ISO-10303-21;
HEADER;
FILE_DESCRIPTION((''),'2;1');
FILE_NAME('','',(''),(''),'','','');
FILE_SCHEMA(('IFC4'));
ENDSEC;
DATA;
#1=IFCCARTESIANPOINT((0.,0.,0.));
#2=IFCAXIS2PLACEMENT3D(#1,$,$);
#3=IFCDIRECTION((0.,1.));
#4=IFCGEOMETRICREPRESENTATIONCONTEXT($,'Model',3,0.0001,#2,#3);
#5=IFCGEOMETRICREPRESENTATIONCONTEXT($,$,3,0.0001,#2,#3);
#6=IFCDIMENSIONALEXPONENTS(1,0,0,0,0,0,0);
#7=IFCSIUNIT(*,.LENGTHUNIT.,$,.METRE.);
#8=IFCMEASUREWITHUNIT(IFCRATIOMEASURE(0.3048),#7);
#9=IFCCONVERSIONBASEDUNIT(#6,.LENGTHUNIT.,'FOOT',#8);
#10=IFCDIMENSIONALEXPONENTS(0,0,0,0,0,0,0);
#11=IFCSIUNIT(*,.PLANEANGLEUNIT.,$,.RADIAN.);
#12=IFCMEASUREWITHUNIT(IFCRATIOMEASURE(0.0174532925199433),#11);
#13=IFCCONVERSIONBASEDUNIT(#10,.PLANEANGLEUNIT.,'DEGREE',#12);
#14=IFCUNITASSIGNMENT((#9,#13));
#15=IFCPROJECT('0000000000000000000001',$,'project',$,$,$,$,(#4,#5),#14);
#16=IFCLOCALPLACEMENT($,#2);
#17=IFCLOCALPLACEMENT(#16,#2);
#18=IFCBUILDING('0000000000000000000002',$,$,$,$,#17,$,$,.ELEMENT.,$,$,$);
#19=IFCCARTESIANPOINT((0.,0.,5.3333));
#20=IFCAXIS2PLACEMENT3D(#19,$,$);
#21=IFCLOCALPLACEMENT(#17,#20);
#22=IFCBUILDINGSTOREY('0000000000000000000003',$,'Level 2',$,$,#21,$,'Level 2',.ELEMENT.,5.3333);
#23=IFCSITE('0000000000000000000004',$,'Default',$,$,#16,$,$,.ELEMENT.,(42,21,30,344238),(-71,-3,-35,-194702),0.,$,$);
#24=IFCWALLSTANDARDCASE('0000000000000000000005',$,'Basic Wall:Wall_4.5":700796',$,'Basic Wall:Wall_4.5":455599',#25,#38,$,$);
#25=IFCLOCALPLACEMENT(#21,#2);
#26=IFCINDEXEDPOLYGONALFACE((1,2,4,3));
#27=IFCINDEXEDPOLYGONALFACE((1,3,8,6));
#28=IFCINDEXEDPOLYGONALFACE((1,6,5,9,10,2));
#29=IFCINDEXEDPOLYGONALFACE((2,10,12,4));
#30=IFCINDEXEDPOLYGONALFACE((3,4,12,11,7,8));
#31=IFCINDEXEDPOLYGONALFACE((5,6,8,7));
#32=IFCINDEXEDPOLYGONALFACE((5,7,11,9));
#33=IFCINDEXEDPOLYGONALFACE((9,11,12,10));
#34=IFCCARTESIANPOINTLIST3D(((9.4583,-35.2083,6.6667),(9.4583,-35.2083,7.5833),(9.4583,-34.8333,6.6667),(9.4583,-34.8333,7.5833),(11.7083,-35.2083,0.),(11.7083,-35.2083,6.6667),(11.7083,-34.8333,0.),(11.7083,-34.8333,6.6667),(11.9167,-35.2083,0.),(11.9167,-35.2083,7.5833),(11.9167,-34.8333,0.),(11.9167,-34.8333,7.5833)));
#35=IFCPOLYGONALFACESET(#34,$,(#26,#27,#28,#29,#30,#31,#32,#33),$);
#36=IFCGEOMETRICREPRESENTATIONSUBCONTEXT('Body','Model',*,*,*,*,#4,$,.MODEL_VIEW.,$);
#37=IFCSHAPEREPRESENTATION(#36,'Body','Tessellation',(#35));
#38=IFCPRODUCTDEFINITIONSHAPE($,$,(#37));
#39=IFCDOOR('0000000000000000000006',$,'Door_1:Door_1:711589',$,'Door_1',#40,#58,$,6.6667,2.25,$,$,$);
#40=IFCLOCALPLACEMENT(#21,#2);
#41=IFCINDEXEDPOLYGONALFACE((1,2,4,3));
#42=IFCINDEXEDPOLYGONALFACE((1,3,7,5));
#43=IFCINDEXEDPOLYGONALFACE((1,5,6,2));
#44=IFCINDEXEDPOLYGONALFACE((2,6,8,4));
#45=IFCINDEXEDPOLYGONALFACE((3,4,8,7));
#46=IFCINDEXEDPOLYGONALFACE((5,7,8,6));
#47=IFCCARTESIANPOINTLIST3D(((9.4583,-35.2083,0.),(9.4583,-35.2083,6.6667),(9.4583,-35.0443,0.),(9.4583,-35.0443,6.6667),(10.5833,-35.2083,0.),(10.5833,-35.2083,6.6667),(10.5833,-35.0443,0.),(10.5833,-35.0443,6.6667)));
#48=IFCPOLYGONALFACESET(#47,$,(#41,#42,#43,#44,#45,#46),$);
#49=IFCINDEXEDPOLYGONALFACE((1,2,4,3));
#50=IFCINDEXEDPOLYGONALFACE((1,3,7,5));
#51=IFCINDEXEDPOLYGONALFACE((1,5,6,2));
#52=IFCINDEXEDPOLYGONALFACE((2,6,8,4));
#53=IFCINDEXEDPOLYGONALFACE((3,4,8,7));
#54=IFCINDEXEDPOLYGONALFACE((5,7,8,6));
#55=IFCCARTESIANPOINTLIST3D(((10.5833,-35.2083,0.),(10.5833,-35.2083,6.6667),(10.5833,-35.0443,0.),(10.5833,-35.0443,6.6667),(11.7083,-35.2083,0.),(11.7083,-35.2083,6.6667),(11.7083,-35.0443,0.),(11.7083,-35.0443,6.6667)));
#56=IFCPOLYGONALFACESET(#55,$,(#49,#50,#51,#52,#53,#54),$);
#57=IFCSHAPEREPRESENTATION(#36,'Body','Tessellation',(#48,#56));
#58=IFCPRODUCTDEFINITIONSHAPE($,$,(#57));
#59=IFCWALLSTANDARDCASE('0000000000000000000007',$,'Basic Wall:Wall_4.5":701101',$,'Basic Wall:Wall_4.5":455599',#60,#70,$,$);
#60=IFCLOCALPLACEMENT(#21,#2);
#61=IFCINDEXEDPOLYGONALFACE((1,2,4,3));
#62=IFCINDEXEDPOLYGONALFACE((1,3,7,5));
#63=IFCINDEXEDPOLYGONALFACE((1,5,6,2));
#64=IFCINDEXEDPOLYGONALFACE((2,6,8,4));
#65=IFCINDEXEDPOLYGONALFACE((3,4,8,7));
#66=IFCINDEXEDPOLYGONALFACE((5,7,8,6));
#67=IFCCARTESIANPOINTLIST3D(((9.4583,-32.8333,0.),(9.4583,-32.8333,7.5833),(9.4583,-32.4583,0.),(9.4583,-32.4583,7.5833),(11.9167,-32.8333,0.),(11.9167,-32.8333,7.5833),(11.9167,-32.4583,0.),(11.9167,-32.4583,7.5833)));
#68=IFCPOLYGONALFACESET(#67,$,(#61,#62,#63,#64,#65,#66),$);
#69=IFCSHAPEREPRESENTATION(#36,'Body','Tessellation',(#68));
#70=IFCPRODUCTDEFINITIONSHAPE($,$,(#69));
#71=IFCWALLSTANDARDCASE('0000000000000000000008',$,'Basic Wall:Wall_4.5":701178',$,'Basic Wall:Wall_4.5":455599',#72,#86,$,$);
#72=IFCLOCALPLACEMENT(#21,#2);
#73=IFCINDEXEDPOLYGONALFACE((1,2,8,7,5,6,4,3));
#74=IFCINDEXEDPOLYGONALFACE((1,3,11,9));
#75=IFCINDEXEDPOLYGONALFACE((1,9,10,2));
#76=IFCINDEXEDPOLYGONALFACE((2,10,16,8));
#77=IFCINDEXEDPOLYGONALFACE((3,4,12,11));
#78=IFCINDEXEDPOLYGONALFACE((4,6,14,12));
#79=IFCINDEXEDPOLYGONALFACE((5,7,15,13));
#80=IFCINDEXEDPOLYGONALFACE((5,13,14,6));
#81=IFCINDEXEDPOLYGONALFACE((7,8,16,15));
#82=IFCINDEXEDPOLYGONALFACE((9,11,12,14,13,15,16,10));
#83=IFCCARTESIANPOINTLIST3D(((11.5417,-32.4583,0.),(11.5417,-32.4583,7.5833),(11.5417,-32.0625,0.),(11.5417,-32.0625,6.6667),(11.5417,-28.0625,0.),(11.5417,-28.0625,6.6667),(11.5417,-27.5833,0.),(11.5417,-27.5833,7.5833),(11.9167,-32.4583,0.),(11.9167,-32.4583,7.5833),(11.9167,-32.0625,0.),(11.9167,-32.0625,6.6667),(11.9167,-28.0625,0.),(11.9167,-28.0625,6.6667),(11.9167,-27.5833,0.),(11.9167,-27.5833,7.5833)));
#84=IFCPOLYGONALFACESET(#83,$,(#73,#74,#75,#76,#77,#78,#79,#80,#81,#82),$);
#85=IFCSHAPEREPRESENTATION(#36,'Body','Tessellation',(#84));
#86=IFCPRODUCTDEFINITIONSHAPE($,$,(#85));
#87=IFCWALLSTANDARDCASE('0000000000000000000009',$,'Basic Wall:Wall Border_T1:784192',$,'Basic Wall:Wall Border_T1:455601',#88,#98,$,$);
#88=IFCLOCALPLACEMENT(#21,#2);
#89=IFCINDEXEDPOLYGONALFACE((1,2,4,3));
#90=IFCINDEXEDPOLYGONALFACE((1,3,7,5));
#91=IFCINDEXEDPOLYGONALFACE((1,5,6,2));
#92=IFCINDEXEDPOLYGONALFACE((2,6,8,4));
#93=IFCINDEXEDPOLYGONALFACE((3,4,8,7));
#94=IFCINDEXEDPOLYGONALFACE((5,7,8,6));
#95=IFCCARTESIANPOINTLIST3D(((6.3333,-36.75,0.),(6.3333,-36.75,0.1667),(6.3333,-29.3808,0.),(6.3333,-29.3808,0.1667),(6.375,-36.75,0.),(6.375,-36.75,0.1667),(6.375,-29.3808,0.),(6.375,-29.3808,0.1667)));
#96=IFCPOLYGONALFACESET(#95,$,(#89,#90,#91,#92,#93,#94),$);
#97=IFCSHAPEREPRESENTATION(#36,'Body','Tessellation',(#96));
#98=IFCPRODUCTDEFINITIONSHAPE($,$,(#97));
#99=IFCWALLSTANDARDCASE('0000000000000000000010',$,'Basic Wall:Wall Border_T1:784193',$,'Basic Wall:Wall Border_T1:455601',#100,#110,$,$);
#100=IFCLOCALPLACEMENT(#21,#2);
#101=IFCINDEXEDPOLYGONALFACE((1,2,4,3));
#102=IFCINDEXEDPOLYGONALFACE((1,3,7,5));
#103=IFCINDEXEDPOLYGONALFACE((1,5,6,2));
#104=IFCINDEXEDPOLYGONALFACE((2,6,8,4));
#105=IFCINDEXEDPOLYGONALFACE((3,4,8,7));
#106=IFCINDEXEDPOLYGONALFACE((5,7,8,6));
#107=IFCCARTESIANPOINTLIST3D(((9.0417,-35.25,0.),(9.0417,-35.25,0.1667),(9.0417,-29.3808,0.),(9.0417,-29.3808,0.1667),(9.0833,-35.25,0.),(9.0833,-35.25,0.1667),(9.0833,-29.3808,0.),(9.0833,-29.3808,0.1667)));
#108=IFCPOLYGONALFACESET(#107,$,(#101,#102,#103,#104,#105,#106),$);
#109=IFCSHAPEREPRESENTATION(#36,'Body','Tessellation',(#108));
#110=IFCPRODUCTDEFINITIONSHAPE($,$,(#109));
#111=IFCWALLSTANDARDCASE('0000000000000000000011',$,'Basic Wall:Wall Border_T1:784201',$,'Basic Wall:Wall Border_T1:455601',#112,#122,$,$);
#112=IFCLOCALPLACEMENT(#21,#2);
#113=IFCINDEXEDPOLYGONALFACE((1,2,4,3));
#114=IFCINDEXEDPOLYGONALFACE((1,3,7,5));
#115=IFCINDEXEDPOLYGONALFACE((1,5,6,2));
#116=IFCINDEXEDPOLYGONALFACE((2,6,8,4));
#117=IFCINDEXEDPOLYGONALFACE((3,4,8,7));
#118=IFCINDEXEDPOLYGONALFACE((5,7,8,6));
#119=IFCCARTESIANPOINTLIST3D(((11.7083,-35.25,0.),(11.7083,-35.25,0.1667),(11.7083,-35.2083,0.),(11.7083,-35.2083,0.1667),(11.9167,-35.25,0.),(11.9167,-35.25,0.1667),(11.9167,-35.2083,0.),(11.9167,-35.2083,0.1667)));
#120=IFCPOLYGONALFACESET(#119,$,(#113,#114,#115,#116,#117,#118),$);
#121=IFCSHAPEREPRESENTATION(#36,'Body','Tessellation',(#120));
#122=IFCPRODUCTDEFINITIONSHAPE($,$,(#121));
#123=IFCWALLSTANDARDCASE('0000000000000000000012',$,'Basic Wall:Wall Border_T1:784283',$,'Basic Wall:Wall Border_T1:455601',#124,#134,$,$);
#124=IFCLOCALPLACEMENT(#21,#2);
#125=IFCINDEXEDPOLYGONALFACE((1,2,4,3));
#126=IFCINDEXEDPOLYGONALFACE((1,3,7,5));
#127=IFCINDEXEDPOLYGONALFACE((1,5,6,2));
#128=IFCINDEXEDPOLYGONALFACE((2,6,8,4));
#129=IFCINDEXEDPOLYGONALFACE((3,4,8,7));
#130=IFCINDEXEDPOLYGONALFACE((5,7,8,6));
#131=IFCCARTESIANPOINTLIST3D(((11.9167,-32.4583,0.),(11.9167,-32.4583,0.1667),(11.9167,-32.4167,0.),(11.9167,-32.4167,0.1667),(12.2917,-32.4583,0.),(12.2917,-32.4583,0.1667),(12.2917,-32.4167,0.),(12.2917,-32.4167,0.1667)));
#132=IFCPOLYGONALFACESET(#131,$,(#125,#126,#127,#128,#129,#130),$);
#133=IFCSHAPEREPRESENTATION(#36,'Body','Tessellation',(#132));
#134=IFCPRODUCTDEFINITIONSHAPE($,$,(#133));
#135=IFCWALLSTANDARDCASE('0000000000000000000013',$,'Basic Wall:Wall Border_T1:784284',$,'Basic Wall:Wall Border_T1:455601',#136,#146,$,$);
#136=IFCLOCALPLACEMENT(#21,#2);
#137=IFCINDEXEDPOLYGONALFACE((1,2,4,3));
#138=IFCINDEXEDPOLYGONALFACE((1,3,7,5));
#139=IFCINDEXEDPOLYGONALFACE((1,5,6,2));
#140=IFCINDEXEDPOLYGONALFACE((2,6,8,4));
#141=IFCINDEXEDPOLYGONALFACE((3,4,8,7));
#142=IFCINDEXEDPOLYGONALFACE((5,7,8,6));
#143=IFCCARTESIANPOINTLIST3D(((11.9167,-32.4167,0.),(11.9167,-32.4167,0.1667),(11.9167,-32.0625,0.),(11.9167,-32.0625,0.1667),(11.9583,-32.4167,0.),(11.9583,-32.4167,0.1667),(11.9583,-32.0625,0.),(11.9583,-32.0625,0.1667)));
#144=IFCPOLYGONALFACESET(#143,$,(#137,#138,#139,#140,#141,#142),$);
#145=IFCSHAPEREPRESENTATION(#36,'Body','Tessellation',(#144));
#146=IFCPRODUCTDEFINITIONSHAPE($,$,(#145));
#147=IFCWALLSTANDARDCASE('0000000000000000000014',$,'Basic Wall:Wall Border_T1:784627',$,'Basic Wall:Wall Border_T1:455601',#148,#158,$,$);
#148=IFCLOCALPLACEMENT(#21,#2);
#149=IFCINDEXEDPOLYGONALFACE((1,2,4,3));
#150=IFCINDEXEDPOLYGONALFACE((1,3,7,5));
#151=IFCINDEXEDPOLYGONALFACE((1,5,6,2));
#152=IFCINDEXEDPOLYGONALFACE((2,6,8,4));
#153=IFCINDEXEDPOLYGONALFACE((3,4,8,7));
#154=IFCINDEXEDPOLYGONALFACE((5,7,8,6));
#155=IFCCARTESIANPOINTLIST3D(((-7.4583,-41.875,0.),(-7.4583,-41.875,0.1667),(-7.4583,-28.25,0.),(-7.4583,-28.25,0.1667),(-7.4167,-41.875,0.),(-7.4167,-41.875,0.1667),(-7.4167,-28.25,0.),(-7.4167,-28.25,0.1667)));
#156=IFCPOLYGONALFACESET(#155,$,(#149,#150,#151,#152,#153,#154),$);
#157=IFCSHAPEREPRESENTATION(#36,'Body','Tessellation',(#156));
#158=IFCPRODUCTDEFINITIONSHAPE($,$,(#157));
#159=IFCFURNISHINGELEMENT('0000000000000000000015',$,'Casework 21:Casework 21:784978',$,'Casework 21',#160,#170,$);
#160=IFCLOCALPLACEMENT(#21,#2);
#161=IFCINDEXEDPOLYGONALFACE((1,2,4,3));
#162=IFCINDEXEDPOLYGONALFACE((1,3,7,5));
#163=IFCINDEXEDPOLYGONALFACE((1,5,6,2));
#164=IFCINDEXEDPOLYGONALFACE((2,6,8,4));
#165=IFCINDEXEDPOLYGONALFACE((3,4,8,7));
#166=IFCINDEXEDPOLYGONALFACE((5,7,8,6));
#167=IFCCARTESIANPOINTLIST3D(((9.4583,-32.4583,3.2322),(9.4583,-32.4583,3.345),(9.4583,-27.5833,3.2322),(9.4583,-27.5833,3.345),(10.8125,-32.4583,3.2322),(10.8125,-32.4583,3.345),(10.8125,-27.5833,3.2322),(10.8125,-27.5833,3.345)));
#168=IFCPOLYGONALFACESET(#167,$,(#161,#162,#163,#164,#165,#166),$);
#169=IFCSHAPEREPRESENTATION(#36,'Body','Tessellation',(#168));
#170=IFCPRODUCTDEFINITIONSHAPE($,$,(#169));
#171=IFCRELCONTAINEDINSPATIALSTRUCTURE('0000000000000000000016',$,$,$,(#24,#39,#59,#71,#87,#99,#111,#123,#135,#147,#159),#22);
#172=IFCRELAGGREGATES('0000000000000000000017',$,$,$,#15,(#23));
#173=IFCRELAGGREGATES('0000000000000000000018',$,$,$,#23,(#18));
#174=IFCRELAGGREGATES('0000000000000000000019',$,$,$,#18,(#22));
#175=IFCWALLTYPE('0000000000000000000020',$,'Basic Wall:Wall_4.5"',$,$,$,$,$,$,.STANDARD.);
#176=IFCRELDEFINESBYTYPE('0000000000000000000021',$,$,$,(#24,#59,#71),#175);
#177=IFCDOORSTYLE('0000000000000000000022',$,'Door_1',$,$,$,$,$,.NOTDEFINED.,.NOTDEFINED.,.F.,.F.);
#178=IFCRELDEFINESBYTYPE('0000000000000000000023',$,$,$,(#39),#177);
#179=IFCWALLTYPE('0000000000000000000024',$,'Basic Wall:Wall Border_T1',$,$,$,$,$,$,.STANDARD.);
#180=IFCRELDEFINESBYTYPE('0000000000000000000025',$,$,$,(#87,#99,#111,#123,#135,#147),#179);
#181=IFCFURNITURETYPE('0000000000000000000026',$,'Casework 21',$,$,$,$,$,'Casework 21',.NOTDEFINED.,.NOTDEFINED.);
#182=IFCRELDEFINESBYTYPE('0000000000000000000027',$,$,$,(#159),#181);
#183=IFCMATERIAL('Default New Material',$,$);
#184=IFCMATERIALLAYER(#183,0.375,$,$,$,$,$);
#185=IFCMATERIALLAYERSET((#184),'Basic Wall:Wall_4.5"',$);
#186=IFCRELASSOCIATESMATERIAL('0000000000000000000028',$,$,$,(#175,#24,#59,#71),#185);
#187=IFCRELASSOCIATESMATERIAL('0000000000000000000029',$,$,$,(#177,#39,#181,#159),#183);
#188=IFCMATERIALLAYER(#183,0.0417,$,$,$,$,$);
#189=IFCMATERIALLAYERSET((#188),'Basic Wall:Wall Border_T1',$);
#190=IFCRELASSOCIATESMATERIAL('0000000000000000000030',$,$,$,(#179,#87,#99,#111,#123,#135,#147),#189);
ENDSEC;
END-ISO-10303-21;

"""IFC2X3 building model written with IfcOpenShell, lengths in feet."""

from ifc_helpers import new_model, entity, si_unit, converted_unit, direction, frame, frame_2d, origin, origin_2d_with_axis, place, context, subcontext, project, spatial, rectangle, extrude, source, transform, mapped, material, layer, layer_set, layer_usage, type_object, type_shapes, element, fill, save


model = new_model("IFC2X3")

# Units and contexts
model_context = context("Model", 3, precision=0.0001, world=origin(), true_north=direction((0.0, 1.0)))
context_of_model = context(None, 3, precision=0.0001, world=origin(), true_north=direction((0.0, 1.0)))
body_context = subcontext(model_context, "Body", "Model", "MODEL_VIEW")
ifc_project = project(units=[converted_unit("LENGTHUNIT", "FOOT", entity("IfcRatioMeasure", 0.3048), si_unit("LENGTHUNIT", "METRE"), dimensions=[1, 0, 0, 0, 0, 0, 0]), converted_unit("PLANEANGLEUNIT", "DEGREE", entity("IfcRatioMeasure", 0.0174532925199433), si_unit("PLANEANGLEUNIT", "RADIAN"), dimensions=[0, 0, 0, 0, 0, 0, 0])], contexts=[model_context, context_of_model])

# Site, building, storey
site_placement = place(None, origin())
site = spatial("IfcSite", under=ifc_project, at=site_placement, Name="Default", CompositionType="ELEMENT", RefLatitude=(42, 21, 30, 344238), RefLongitude=(-71, -3, -35, -194702), RefElevation=0.0)
building_placement = place(site_placement, origin())
building = spatial("IfcBuilding", under=site, at=building_placement, CompositionType="ELEMENT")
storey_placement = place(building_placement, frame((0.0, 0.0, 5.3333)))
storey = spatial("IfcBuildingStorey", under=building, at=storey_placement, Name="Level 2", LongName="Level 2", CompositionType="ELEMENT", Elevation=5.3333)

# Wall, opening, door
ifc_material_1 = material(Name="Default New Material")
ifc_layer_1 = layer(ifc_material_1, 0.375)
ifc_layer_set_1 = layer_set([ifc_layer_1], Name="Basic Wall:Wall_4.5\"")
ifc_layer_usage_1 = layer_usage(ifc_layer_set_1, "AXIS2", "NEGATIVE", 0.1875)
wall_type_1 = type_object("IfcWallType", Name="Basic Wall:Wall_4.5\"", PredefinedType="STANDARD", material=ifc_layer_set_1)
wall_1_placement = place(storey_placement, frame((9.4583, -35.0208, 0.0)))
wall_1 = element("IfcWallStandardCase", 1, at=wall_1_placement, inside=storey, type_object=wall_type_1, material=ifc_layer_usage_1, Name="Basic Wall:Wall_4.5\":700796", ObjectType="Basic Wall:Wall_4.5\":455599", context=body_context, shape_type="SweptSolid", body=[
    extrude(rectangle(XDim=2.4583, YDim=0.375, at=frame_2d((1.2292, 0.0), x_axis=(-1.0, 0.0))), origin(), (0.0, 0.0, 1.0), 7.5833),
])
opening_1_placement = place(wall_1_placement, frame((2.25, 0.1875, 0.0)))
opening_1 = element("IfcOpeningElement", 2, at=opening_1_placement, cuts=wall_1, ObjectType="Opening", context=body_context, shape_type="SweptSolid", body=[
    extrude(rectangle(XDim=6.6667, YDim=2.25, at=frame_2d((3.3333, 1.125), x_axis=(1.0, 0.0))), frame((0.0, 0.0, 0.0), z_axis=(0.0, -1.0, 0.0), x_axis=(0.0, 0.0, 1.0)), (0.0, 0.0, 1.0), 0.375),
])
door_style_1 = type_object("IfcDoorStyle", Name="Door_1", ConstructionType="NOTDEFINED", OperationType="NOTDEFINED", ParameterTakesPrecedence=False, Sizeable=False, material=ifc_material_1)
shared_shape_1 = source(origin(), body_context, "Body", "SweptSolid", [
    extrude(rectangle(XDim=0.164, YDim=1.125, at=origin_2d_with_axis()), frame((1.6875, 0.293, 0.0), z_axis=(0.0, 0.0, 1.0), x_axis=(0.0, -1.0, 0.0)), (0.0, 0.0, 1.0), 6.6667),
    extrude(rectangle(XDim=0.164, YDim=1.125, at=origin_2d_with_axis()), frame((0.5625, 0.293, 0.0), z_axis=(0.0, 0.0, 1.0), x_axis=(0.0, -1.0, 0.0)), (0.0, 0.0, 1.0), 6.6667),
])
type_shapes(door_style_1, [shared_shape_1])
door_1_placement = place(opening_1_placement, frame((0.0, 0.0, 0.0), z_axis=(0.0, 0.0, 1.0), x_axis=(-1.0, 0.0, 0.0)))
door_1 = element("IfcDoor", 3, at=door_1_placement, inside=storey, type_object=door_style_1, material=ifc_material_1, Name="Door_1:Door_1:711589", ObjectType="Door_1", OverallHeight=6.6667, OverallWidth=2.25, context=body_context, shape_type="MappedRepresentation", body=[
    mapped(shared_shape_1, transform((0.0, 0.0, 0.0), scale=1.0)),
])
fill(opening_1, door_1)

# Wall
ifc_layer_usage_2 = layer_usage(ifc_layer_set_1, "AXIS2", "NEGATIVE", 0.1875)
wall_2_placement = place(storey_placement, frame((11.9167, -32.6458, 0.0), z_axis=(0.0, 0.0, 1.0), x_axis=(-1.0, 0.0, 0.0)))
element("IfcWallStandardCase", 4, at=wall_2_placement, inside=storey, type_object=wall_type_1, material=ifc_layer_usage_2, Name="Basic Wall:Wall_4.5\":701101", ObjectType="Basic Wall:Wall_4.5\":455599", context=body_context, shape_type="SweptSolid", body=[
    extrude(rectangle(XDim=2.4583, YDim=0.375, at=frame_2d((1.2292, 0.0), x_axis=(-1.0, 0.0))), origin(), (0.0, 0.0, 1.0), 7.5833),
])

# Wall, opening
ifc_layer_usage_3 = layer_usage(ifc_layer_set_1, "AXIS2", "NEGATIVE", 0.1875)
wall_3_placement = place(storey_placement, frame((11.7292, -32.4583, 0.0), z_axis=(0.0, 0.0, 1.0), x_axis=(0.0, 1.0, 0.0)))
wall_3 = element("IfcWallStandardCase", 5, at=wall_3_placement, inside=storey, type_object=wall_type_1, material=ifc_layer_usage_3, Name="Basic Wall:Wall_4.5\":701178", ObjectType="Basic Wall:Wall_4.5\":455599", context=body_context, shape_type="SweptSolid", body=[
    extrude(rectangle(XDim=4.875, YDim=0.375, at=frame_2d((2.4375, 0.0), x_axis=(-1.0, 0.0))), origin(), (0.0, 0.0, 1.0), 7.5833),
])
opening_2_placement = place(wall_3_placement, frame((0.3958, 4.8125, 0.0), z_axis=(0.0, 0.0, 1.0), x_axis=(0.0, -1.0, 0.0)))
element("IfcOpeningElement", 6, at=opening_2_placement, cuts=wall_3, ObjectType="Opening", context=body_context, shape_type="SweptSolid", body=[
    extrude(rectangle(XDim=6.6667, YDim=4.0, at=frame_2d((0.0, 0.0), x_axis=(1.0, 0.0))), frame((10.0, 2.0, 3.3333), z_axis=(-1.0, 0.0, 0.0), x_axis=(0.0, 0.0, 1.0)), (0.0, 0.0, 1.0), 10.0),
])

# Walls
ifc_layer_2 = layer(ifc_material_1, 0.0417)
ifc_layer_set_2 = layer_set([ifc_layer_2], Name="Basic Wall:Wall Border_T1")
ifc_layer_usage_4 = layer_usage(ifc_layer_set_2, "AXIS2", "NEGATIVE", 0.0208)
wall_type_2 = type_object("IfcWallType", Name="Basic Wall:Wall Border_T1", PredefinedType="STANDARD", material=ifc_layer_set_2)
wall_4_placement = place(storey_placement, frame((6.3542, -29.3808, 0.0), z_axis=(0.0, 0.0, 1.0), x_axis=(0.0, -1.0, 0.0)))
element("IfcWallStandardCase", 7, at=wall_4_placement, inside=storey, type_object=wall_type_2, material=ifc_layer_usage_4, Name="Basic Wall:Wall Border_T1:784192", ObjectType="Basic Wall:Wall Border_T1:455601", context=body_context, shape_type="SweptSolid", body=[
    extrude(rectangle(XDim=7.3692, YDim=0.0417, at=frame_2d((3.6846, 0.0), x_axis=(-1.0, 0.0))), origin(), (0.0, 0.0, 1.0), 0.1667),
])
ifc_layer_usage_5 = layer_usage(ifc_layer_set_2, "AXIS2", "POSITIVE", -0.0208)
wall_5_placement = place(storey_placement, frame((9.0625, -29.3808, 0.0), z_axis=(0.0, 0.0, 1.0), x_axis=(0.0, -1.0, 0.0)))
element("IfcWallStandardCase", 8, at=wall_5_placement, inside=storey, type_object=wall_type_2, material=ifc_layer_usage_5, Name="Basic Wall:Wall Border_T1:784193", ObjectType="Basic Wall:Wall Border_T1:455601", context=body_context, shape_type="SweptSolid", body=[
    extrude(rectangle(XDim=5.8692, YDim=0.0417, at=frame_2d((2.9346, 0.0), x_axis=(-1.0, 0.0))), origin(), (0.0, 0.0, 1.0), 0.1667),
])
ifc_layer_usage_6 = layer_usage(ifc_layer_set_2, "AXIS2", "POSITIVE", -0.0208)
wall_6_placement = place(storey_placement, frame((11.7083, -35.2292, 0.0)))
element("IfcWallStandardCase", 9, at=wall_6_placement, inside=storey, type_object=wall_type_2, material=ifc_layer_usage_6, Name="Basic Wall:Wall Border_T1:784201", ObjectType="Basic Wall:Wall Border_T1:455601", context=body_context, shape_type="SweptSolid", body=[
    extrude(rectangle(XDim=0.2083, YDim=0.0417, at=frame_2d((0.1042, 0.0), x_axis=(-1.0, 0.0))), origin(), (0.0, 0.0, 1.0), 0.1667),
])
ifc_layer_usage_7 = layer_usage(ifc_layer_set_2, "AXIS2", "POSITIVE", -0.0208)
wall_7_placement = place(storey_placement, frame((12.2917, -32.4375, 0.0), z_axis=(0.0, 0.0, 1.0), x_axis=(-1.0, 0.0, 0.0)))
element("IfcWallStandardCase", 10, at=wall_7_placement, inside=storey, type_object=wall_type_2, material=ifc_layer_usage_7, Name="Basic Wall:Wall Border_T1:784283", ObjectType="Basic Wall:Wall Border_T1:455601", context=body_context, shape_type="SweptSolid", body=[
    extrude(rectangle(XDim=0.375, YDim=0.0417, at=frame_2d((0.1875, 0.0), x_axis=(-1.0, 0.0))), origin(), (0.0, 0.0, 1.0), 0.1667),
])
ifc_layer_usage_8 = layer_usage(ifc_layer_set_2, "AXIS2", "POSITIVE", -0.0208)
wall_8_placement = place(storey_placement, frame((11.9375, -32.4167, 0.0), z_axis=(0.0, 0.0, 1.0), x_axis=(0.0, 1.0, 0.0)))
element("IfcWallStandardCase", 11, at=wall_8_placement, inside=storey, type_object=wall_type_2, material=ifc_layer_usage_8, Name="Basic Wall:Wall Border_T1:784284", ObjectType="Basic Wall:Wall Border_T1:455601", context=body_context, shape_type="SweptSolid", body=[
    extrude(rectangle(XDim=0.3542, YDim=0.0417, at=frame_2d((0.1771, 0.0), x_axis=(-1.0, 0.0))), origin(), (0.0, 0.0, 1.0), 0.1667),
])
ifc_layer_usage_9 = layer_usage(ifc_layer_set_2, "AXIS2", "NEGATIVE", 0.0208)
wall_9_placement = place(storey_placement, frame((-7.4375, -28.25, 0.0), z_axis=(0.0, 0.0, 1.0), x_axis=(0.0, -1.0, 0.0)))
element("IfcWallStandardCase", 12, at=wall_9_placement, inside=storey, type_object=wall_type_2, material=ifc_layer_usage_9, Name="Basic Wall:Wall Border_T1:784627", ObjectType="Basic Wall:Wall Border_T1:455601", context=body_context, shape_type="SweptSolid", body=[
    extrude(rectangle(XDim=13.625, YDim=0.0417, at=frame_2d((6.8125, 0.0), x_axis=(-1.0, 0.0))), origin(), (0.0, 0.0, 1.0), 0.1667),
])

# Furnishing element
furniture_type = type_object("IfcFurnitureType", Name="Casework 21", ElementType="Casework 21", AssemblyPlace="NOTDEFINED", material=ifc_material_1)
shared_shape_2 = source(origin(), body_context, "Body", "SweptSolid", [
    extrude(rectangle(XDim=1.3542, YDim=4.875, at=frame_2d((0.0, 0.0), x_axis=(1.0, 0.0))), frame((0.6771, 2.4375, 0.0), z_axis=(0.0, 0.0, 1.0), x_axis=(-1.0, 0.0, 0.0)), (0.0, 0.0, 1.0), 0.1128),
])
type_shapes(furniture_type, [shared_shape_2])
furnishing_placement = place(storey_placement, frame((9.4583, -32.4583, 3.2322)))
element("IfcFurnishingElement", 13, at=furnishing_placement, inside=storey, type_object=furniture_type, material=ifc_material_1, Name="Casework 21:Casework 21:784978", ObjectType="Casework 21", context=body_context, shape_type="MappedRepresentation", body=[
    mapped(shared_shape_2, transform((0.0, 0.0, 0.0), scale=1.0)),
])

save(model, "model.ifc")
